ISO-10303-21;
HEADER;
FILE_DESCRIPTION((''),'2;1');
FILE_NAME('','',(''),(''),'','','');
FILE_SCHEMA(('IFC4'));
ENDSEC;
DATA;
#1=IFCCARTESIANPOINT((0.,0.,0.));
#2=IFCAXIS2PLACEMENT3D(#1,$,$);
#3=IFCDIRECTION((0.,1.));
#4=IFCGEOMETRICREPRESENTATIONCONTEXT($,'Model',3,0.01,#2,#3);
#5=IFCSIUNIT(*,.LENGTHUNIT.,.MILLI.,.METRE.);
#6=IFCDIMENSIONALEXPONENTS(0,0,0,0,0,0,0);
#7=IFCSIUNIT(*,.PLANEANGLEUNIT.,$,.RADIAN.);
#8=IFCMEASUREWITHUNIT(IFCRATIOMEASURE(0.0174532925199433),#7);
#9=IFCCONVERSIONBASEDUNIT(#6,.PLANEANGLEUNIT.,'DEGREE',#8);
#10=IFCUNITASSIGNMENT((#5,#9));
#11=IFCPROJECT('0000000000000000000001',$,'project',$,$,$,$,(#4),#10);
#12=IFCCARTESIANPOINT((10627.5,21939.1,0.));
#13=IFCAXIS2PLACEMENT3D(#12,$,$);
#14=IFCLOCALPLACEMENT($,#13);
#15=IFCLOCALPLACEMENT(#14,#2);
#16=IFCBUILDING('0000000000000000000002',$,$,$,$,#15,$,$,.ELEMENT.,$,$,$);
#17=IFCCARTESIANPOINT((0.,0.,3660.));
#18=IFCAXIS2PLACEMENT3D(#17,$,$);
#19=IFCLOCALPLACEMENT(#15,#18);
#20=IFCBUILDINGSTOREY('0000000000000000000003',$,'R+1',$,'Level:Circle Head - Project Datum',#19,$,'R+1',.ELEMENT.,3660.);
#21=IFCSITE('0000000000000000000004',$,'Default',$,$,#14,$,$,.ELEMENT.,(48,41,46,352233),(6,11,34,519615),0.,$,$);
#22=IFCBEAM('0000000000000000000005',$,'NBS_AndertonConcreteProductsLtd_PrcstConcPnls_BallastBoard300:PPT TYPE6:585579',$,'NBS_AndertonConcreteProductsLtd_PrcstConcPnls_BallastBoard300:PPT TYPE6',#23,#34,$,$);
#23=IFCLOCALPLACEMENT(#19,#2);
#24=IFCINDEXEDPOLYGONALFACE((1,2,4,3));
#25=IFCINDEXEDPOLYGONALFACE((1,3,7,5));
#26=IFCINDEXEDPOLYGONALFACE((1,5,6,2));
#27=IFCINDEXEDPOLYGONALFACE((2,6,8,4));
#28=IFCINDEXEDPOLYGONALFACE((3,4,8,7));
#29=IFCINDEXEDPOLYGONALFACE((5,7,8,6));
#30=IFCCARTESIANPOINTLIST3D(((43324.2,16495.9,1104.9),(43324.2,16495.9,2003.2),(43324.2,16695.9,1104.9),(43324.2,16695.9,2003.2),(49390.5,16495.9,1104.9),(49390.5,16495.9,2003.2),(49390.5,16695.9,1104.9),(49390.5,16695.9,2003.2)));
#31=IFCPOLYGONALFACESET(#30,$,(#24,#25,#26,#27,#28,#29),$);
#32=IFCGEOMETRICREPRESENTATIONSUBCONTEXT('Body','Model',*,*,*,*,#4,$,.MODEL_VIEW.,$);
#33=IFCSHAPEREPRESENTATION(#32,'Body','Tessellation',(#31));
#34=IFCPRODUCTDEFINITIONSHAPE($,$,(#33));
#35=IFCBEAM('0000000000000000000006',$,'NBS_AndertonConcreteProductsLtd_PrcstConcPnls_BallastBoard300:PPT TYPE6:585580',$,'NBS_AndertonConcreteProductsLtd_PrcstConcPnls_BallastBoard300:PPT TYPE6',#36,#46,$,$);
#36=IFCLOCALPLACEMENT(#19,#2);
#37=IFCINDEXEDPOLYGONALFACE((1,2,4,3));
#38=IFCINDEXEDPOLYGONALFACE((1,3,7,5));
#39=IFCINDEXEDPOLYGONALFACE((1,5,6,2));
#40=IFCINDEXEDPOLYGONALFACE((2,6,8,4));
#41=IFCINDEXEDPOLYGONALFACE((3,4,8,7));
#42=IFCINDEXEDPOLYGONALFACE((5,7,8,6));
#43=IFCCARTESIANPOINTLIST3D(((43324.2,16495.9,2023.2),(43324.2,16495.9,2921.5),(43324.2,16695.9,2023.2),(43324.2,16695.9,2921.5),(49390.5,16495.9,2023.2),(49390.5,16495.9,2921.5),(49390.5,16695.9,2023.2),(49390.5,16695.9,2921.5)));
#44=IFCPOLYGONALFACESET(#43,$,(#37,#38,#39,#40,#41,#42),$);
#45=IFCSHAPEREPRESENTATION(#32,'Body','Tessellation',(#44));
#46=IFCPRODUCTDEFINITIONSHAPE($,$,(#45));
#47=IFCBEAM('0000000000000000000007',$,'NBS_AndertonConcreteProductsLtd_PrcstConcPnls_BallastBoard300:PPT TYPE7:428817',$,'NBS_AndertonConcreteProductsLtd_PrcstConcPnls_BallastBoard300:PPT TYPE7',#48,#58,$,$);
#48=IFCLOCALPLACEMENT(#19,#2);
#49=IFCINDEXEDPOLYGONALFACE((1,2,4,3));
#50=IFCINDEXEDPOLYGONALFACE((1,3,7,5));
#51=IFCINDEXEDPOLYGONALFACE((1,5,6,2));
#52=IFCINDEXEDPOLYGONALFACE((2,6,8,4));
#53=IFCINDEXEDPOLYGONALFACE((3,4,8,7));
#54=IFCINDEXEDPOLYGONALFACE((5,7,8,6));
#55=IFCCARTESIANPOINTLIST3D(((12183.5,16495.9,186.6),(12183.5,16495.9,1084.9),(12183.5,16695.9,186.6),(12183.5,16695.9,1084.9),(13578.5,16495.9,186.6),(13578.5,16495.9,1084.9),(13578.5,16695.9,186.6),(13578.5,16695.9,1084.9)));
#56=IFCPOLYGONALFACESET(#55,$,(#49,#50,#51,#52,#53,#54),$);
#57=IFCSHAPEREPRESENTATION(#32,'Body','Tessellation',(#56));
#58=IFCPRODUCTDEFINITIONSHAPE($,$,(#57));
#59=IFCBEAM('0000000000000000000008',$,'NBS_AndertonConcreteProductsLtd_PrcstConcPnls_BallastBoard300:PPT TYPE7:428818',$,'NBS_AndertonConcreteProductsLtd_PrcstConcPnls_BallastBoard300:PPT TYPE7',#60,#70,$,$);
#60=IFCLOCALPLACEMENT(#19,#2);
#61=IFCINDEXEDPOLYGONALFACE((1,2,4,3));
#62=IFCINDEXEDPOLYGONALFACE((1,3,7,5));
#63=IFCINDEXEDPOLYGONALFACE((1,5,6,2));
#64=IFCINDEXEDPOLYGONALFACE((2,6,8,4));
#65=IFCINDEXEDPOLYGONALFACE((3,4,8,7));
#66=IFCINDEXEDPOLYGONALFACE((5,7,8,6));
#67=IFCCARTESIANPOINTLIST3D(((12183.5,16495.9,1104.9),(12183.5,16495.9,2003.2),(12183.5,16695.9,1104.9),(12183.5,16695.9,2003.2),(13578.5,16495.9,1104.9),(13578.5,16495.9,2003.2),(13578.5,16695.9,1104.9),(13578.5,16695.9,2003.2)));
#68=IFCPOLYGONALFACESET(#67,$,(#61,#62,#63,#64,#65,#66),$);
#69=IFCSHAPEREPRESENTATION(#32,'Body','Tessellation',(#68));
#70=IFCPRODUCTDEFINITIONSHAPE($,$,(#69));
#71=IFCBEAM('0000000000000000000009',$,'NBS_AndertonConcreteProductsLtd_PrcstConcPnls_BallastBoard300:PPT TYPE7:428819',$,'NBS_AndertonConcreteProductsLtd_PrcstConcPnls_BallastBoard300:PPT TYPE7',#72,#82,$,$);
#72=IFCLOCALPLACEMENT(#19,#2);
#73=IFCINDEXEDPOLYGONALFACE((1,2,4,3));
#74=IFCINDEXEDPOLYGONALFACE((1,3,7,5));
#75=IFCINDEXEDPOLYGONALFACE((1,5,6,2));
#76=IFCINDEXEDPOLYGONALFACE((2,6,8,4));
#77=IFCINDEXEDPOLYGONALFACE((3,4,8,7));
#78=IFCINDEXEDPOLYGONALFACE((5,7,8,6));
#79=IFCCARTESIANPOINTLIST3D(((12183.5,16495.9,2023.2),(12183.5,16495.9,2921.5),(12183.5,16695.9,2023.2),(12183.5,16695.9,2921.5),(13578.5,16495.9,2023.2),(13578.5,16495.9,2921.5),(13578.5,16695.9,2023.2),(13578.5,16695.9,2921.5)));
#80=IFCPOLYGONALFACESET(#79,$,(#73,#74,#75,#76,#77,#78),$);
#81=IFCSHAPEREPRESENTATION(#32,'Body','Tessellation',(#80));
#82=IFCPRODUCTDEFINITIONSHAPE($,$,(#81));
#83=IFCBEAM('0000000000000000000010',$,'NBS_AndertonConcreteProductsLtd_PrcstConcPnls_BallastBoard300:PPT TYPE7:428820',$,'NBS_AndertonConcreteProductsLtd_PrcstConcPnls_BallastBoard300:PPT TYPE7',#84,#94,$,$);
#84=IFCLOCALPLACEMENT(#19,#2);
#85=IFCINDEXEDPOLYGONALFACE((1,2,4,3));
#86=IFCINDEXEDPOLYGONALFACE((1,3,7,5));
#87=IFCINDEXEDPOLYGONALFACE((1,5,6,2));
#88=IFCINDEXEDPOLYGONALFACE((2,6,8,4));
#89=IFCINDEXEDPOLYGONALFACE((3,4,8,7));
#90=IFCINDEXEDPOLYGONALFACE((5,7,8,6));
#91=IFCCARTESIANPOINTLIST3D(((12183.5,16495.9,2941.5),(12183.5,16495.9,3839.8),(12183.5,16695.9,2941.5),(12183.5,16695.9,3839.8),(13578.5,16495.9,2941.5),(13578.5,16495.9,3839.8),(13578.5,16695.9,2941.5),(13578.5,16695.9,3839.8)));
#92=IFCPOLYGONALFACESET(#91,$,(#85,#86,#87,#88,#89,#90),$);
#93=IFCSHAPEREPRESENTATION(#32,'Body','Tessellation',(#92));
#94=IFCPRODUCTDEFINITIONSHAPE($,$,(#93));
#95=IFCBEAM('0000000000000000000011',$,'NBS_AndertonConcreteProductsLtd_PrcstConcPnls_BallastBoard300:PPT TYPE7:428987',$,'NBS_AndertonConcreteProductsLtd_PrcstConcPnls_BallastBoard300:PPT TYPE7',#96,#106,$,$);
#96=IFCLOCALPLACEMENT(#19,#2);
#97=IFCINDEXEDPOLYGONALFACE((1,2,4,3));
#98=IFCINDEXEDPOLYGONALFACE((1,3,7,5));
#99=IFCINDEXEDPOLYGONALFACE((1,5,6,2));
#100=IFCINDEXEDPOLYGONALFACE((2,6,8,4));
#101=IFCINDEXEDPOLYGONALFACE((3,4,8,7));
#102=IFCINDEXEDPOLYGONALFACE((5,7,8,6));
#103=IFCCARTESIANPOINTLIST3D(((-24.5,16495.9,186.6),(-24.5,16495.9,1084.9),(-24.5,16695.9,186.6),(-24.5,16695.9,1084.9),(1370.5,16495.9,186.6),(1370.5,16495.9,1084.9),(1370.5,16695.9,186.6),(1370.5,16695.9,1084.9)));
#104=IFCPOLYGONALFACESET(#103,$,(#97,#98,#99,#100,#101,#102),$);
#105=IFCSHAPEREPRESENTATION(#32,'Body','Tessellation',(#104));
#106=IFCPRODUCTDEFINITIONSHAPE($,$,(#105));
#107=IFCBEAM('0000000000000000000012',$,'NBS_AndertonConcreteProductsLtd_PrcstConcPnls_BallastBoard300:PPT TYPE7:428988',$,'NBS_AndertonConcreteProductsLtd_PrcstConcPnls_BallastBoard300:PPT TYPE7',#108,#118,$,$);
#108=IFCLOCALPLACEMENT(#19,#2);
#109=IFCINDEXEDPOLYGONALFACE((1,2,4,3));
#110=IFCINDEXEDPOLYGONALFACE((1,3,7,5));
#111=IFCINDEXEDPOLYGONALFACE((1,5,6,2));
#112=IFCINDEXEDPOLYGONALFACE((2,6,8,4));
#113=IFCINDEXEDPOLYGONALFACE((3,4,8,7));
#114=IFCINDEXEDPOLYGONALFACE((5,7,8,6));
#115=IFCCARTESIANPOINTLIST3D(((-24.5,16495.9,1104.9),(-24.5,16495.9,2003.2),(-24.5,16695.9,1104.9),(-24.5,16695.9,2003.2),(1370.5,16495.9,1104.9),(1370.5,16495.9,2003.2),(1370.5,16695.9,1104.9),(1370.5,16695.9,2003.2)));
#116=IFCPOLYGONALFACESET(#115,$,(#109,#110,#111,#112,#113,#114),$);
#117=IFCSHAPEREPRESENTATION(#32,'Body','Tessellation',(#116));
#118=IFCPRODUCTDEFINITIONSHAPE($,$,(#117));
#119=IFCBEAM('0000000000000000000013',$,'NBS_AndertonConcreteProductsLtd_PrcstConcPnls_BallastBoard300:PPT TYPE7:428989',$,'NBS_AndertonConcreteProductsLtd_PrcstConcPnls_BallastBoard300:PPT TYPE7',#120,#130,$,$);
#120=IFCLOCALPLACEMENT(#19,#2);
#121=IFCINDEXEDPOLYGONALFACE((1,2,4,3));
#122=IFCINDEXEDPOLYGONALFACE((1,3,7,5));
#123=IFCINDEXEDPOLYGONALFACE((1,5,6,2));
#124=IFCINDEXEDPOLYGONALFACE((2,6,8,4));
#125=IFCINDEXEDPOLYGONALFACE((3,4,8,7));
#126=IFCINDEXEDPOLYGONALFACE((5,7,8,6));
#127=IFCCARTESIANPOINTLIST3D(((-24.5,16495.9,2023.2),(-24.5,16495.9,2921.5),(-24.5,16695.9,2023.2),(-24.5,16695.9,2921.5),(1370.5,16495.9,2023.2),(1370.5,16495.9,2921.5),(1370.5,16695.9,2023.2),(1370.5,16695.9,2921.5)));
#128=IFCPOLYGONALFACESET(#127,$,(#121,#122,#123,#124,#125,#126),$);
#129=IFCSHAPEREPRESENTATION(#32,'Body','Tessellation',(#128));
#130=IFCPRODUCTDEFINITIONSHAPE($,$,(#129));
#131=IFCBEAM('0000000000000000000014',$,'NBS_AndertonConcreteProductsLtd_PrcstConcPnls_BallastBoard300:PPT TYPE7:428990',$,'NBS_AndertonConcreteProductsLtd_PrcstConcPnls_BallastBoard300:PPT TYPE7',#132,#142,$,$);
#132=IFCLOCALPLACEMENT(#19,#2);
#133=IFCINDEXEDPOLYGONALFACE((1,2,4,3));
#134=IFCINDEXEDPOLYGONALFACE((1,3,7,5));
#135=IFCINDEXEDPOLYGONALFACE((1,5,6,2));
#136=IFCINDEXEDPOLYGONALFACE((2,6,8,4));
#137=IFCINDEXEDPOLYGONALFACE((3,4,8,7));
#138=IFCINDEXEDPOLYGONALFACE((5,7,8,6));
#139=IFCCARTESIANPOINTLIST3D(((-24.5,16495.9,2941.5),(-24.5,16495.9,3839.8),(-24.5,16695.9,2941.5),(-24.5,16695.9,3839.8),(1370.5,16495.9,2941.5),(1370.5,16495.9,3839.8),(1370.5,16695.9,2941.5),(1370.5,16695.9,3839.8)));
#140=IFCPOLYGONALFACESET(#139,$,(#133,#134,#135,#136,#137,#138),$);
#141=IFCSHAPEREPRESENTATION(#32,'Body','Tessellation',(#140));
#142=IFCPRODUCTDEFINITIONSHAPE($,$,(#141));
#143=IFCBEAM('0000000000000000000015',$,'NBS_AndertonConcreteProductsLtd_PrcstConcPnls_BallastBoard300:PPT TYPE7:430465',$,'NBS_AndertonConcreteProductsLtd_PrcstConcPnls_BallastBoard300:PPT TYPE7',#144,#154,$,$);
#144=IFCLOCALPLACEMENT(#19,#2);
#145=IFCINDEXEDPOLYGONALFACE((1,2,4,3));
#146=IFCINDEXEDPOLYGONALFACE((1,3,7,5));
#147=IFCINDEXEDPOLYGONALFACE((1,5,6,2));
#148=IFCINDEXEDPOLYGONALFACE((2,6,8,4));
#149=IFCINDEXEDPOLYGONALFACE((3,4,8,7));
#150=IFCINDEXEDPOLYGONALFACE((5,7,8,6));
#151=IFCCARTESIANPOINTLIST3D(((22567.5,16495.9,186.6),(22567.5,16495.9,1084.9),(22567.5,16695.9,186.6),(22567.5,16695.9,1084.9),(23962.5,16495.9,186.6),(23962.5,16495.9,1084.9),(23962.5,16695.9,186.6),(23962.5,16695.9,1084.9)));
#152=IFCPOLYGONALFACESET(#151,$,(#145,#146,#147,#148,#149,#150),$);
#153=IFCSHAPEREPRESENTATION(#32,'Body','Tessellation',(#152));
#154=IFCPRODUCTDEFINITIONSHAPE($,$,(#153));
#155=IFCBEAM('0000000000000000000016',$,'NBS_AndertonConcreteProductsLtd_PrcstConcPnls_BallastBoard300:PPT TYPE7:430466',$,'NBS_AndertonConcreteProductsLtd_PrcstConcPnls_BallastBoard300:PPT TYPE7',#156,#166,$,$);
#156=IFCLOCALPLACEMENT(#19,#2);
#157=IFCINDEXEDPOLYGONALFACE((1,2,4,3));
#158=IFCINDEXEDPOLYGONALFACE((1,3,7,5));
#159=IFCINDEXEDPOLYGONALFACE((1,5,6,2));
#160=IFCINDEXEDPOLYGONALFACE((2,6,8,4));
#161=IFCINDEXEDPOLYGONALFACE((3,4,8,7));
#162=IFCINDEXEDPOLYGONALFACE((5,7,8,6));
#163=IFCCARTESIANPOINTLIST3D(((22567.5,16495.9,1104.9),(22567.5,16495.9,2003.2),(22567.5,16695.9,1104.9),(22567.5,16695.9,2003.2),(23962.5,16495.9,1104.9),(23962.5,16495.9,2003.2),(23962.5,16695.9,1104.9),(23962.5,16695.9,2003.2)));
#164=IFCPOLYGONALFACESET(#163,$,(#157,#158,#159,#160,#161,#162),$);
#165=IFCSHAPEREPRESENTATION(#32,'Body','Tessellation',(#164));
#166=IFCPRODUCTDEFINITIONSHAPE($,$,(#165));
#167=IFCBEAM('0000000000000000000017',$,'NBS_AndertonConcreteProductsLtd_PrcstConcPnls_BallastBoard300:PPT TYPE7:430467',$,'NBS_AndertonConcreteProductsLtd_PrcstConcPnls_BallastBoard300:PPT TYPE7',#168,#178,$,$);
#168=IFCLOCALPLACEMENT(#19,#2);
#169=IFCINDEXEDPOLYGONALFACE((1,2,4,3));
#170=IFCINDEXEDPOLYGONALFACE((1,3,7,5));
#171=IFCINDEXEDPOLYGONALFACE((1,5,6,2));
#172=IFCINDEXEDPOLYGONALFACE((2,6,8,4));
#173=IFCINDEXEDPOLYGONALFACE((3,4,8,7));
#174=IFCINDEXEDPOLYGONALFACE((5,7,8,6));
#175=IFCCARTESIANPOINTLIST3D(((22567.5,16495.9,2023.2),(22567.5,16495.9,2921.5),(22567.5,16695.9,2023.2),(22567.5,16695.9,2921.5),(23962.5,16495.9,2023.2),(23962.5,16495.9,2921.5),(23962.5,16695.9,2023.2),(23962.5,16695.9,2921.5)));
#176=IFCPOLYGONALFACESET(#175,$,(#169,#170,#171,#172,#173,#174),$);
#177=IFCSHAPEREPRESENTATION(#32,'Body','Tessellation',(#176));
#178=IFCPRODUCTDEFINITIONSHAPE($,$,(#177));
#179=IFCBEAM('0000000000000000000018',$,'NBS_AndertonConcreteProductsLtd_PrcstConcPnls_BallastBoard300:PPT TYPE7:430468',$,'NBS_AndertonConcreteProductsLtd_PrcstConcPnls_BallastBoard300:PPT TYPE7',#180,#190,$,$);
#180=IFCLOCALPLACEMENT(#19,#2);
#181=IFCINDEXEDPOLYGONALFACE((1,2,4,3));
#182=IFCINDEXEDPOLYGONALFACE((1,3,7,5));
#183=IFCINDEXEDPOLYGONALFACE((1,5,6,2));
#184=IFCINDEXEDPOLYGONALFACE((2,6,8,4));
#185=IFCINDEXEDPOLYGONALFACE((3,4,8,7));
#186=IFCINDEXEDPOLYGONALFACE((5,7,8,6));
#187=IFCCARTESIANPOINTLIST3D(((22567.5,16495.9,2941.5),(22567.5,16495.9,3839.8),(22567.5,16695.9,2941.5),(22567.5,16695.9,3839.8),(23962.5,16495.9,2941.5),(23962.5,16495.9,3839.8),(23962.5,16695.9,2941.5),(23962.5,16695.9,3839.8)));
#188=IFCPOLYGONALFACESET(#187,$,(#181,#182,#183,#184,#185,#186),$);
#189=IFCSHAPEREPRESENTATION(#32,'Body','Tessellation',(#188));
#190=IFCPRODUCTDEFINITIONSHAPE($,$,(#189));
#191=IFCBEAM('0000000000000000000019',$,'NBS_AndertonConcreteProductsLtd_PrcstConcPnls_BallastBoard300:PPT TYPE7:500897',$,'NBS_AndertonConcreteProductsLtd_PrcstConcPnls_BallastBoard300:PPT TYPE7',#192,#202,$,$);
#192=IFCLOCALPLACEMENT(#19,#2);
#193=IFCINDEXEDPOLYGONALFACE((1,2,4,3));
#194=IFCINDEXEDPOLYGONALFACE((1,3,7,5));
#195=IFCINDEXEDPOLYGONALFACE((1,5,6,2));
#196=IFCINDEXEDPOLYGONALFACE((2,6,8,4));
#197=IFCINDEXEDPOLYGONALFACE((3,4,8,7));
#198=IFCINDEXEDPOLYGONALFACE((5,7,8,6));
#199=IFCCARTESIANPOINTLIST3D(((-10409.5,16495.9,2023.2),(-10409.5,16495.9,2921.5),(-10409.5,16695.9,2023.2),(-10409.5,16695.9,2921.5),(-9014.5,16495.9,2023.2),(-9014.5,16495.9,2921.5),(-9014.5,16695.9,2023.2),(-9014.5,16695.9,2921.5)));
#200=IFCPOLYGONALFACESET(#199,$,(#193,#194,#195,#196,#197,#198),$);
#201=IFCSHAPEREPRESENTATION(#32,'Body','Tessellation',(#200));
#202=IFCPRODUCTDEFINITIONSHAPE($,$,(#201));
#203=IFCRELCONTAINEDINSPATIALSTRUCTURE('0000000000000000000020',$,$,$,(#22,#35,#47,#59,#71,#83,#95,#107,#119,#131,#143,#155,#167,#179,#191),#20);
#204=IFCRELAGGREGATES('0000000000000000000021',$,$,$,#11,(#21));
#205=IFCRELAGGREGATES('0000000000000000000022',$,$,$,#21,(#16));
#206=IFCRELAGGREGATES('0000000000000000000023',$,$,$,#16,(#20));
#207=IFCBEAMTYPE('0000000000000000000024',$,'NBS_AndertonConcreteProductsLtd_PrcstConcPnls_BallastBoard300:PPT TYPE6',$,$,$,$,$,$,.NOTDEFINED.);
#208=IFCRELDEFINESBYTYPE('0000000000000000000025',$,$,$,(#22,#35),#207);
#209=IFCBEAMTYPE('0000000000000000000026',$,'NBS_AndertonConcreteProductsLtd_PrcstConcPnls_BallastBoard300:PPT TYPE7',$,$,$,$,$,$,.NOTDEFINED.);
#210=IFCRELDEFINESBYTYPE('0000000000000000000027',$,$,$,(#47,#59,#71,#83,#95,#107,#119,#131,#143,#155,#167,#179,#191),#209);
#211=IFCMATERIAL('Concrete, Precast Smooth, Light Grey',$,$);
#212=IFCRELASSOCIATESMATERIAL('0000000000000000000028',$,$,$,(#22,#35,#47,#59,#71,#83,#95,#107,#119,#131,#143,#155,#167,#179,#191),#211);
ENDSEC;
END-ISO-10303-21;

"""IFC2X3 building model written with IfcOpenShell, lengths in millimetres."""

from ifc_helpers import new_model, entity, si_unit, converted_unit, direction, frame, frame_2d, origin, place, context, subcontext, project, spatial, rectangle, extrude, material, type_object, element, save


model = new_model("IFC2X3")

# Units and contexts
model_context = context("Model", 3, precision=0.01, world=origin(), true_north=direction((0.0, 1.0)))
body_context = subcontext(model_context, "Body", "Model", "MODEL_VIEW")
ifc_project = project(units=[si_unit("LENGTHUNIT", "METRE", prefix="MILLI"), converted_unit("PLANEANGLEUNIT", "DEGREE", entity("IfcRatioMeasure", 0.0174532925199433), si_unit("PLANEANGLEUNIT", "RADIAN"), dimensions=[0, 0, 0, 0, 0, 0, 0])], contexts=[model_context])

# Site, building, storey
site_placement = place(None, frame((10627.5, 21939.1, 0.0)))
site = spatial("IfcSite", under=ifc_project, at=site_placement, Name="Default", CompositionType="ELEMENT", RefLatitude=(48, 41, 46, 352233), RefLongitude=(6, 11, 34, 519615), RefElevation=0.0)
building_placement = place(site_placement, origin())
building = spatial("IfcBuilding", under=site, at=building_placement, CompositionType="ELEMENT")
storey_placement = place(building_placement, frame((0.0, 0.0, 3660.0)))
storey = spatial("IfcBuildingStorey", under=building, at=storey_placement, Name="R+1", ObjectType="Level:Circle Head - Project Datum", LongName="R+1", CompositionType="ELEMENT", Elevation=3660.0)

# Beams
ifc_material = material(Name="Concrete, Precast Smooth, Light Grey")
beam_type_1 = type_object("IfcBeamType", Name="NBS_AndertonConcreteProductsLtd_PrcstConcPnls_BallastBoard300:PPT TYPE6", PredefinedType="NOTDEFINED")
beam_1_placement = place(storey_placement, origin())
element("IfcBeam", 1, at=beam_1_placement, inside=storey, type_object=beam_type_1, material=ifc_material, Name="NBS_AndertonConcreteProductsLtd_PrcstConcPnls_BallastBoard300:PPT TYPE6:585579", ObjectType="NBS_AndertonConcreteProductsLtd_PrcstConcPnls_BallastBoard300:PPT TYPE6", context=body_context, shape_type="SweptSolid", body=[
    extrude(rectangle(XDim=898.3, YDim=200.0, at=frame_2d((0.0, 0.0), x_axis=(1.0, 0.0))), frame((43324.2, 16595.9, 1554.1), z_axis=(1.0, 0.0, 0.0), x_axis=(0.0, 0.0, -1.0)), (0.0, 0.0, 1.0), 6066.3),
])
beam_2_placement = place(storey_placement, origin())
element("IfcBeam", 2, at=beam_2_placement, inside=storey, type_object=beam_type_1, material=ifc_material, Name="NBS_AndertonConcreteProductsLtd_PrcstConcPnls_BallastBoard300:PPT TYPE6:585580", ObjectType="NBS_AndertonConcreteProductsLtd_PrcstConcPnls_BallastBoard300:PPT TYPE6", context=body_context, shape_type="SweptSolid", body=[
    extrude(rectangle(XDim=898.3, YDim=200.0, at=frame_2d((0.0, 0.0), x_axis=(1.0, 0.0))), frame((43324.2, 16595.9, 2472.4), z_axis=(1.0, 0.0, 0.0), x_axis=(0.0, 0.0, -1.0)), (0.0, 0.0, 1.0), 6066.3),
])
beam_type_2 = type_object("IfcBeamType", Name="NBS_AndertonConcreteProductsLtd_PrcstConcPnls_BallastBoard300:PPT TYPE7", PredefinedType="NOTDEFINED")
beam_3_placement = place(storey_placement, origin())
element("IfcBeam", 3, at=beam_3_placement, inside=storey, type_object=beam_type_2, material=ifc_material, Name="NBS_AndertonConcreteProductsLtd_PrcstConcPnls_BallastBoard300:PPT TYPE7:428817", ObjectType="NBS_AndertonConcreteProductsLtd_PrcstConcPnls_BallastBoard300:PPT TYPE7", context=body_context, shape_type="SweptSolid", body=[
    extrude(rectangle(XDim=898.3, YDim=200.0, at=frame_2d((0.0, 0.0), x_axis=(0.0, 1.0))), frame((12183.5, 16595.9, 635.8), z_axis=(1.0, 0.0, 0.0), x_axis=(0.0, 1.0, 0.0)), (0.0, 0.0, 1.0), 1395.0),
])
beam_4_placement = place(storey_placement, origin())
element("IfcBeam", 4, at=beam_4_placement, inside=storey, type_object=beam_type_2, material=ifc_material, Name="NBS_AndertonConcreteProductsLtd_PrcstConcPnls_BallastBoard300:PPT TYPE7:428818", ObjectType="NBS_AndertonConcreteProductsLtd_PrcstConcPnls_BallastBoard300:PPT TYPE7", context=body_context, shape_type="SweptSolid", body=[
    extrude(rectangle(XDim=898.3, YDim=200.0, at=frame_2d((0.0, 0.0), x_axis=(0.0, 1.0))), frame((12183.5, 16595.9, 1554.1), z_axis=(1.0, 0.0, 0.0), x_axis=(0.0, 1.0, 0.0)), (0.0, 0.0, 1.0), 1395.0),
])
beam_5_placement = place(storey_placement, origin())
element("IfcBeam", 5, at=beam_5_placement, inside=storey, type_object=beam_type_2, material=ifc_material, Name="NBS_AndertonConcreteProductsLtd_PrcstConcPnls_BallastBoard300:PPT TYPE7:428819", ObjectType="NBS_AndertonConcreteProductsLtd_PrcstConcPnls_BallastBoard300:PPT TYPE7", context=body_context, shape_type="SweptSolid", body=[
    extrude(rectangle(XDim=898.3, YDim=200.0, at=frame_2d((0.0, 0.0), x_axis=(0.0, 1.0))), frame((12183.5, 16595.9, 2472.4), z_axis=(1.0, 0.0, 0.0), x_axis=(0.0, 1.0, 0.0)), (0.0, 0.0, 1.0), 1395.0),
])
beam_6_placement = place(storey_placement, origin())
element("IfcBeam", 6, at=beam_6_placement, inside=storey, type_object=beam_type_2, material=ifc_material, Name="NBS_AndertonConcreteProductsLtd_PrcstConcPnls_BallastBoard300:PPT TYPE7:428820", ObjectType="NBS_AndertonConcreteProductsLtd_PrcstConcPnls_BallastBoard300:PPT TYPE7", context=body_context, shape_type="SweptSolid", body=[
    extrude(rectangle(XDim=898.3, YDim=200.0, at=frame_2d((0.0, 0.0), x_axis=(0.0, 1.0))), frame((12183.5, 16595.9, 3390.7), z_axis=(1.0, 0.0, 0.0), x_axis=(0.0, 1.0, 0.0)), (0.0, 0.0, 1.0), 1395.0),
])
beam_7_placement = place(storey_placement, origin())
element("IfcBeam", 7, at=beam_7_placement, inside=storey, type_object=beam_type_2, material=ifc_material, Name="NBS_AndertonConcreteProductsLtd_PrcstConcPnls_BallastBoard300:PPT TYPE7:428987", ObjectType="NBS_AndertonConcreteProductsLtd_PrcstConcPnls_BallastBoard300:PPT TYPE7", context=body_context, shape_type="SweptSolid", body=[
    extrude(rectangle(XDim=898.3, YDim=200.0, at=frame_2d((0.0, 0.0), x_axis=(0.0, 1.0))), frame((-24.5, 16595.9, 635.8), z_axis=(1.0, 0.0, 0.0), x_axis=(0.0, 1.0, 0.0)), (0.0, 0.0, 1.0), 1395.0),
])
beam_8_placement = place(storey_placement, origin())
element("IfcBeam", 8, at=beam_8_placement, inside=storey, type_object=beam_type_2, material=ifc_material, Name="NBS_AndertonConcreteProductsLtd_PrcstConcPnls_BallastBoard300:PPT TYPE7:428988", ObjectType="NBS_AndertonConcreteProductsLtd_PrcstConcPnls_BallastBoard300:PPT TYPE7", context=body_context, shape_type="SweptSolid", body=[
    extrude(rectangle(XDim=898.3, YDim=200.0, at=frame_2d((0.0, 0.0), x_axis=(0.0, 1.0))), frame((-24.5, 16595.9, 1554.1), z_axis=(1.0, 0.0, 0.0), x_axis=(0.0, 1.0, 0.0)), (0.0, 0.0, 1.0), 1395.0),
])
beam_9_placement = place(storey_placement, origin())
element("IfcBeam", 9, at=beam_9_placement, inside=storey, type_object=beam_type_2, material=ifc_material, Name="NBS_AndertonConcreteProductsLtd_PrcstConcPnls_BallastBoard300:PPT TYPE7:428989", ObjectType="NBS_AndertonConcreteProductsLtd_PrcstConcPnls_BallastBoard300:PPT TYPE7", context=body_context, shape_type="SweptSolid", body=[
    extrude(rectangle(XDim=898.3, YDim=200.0, at=frame_2d((0.0, 0.0), x_axis=(0.0, 1.0))), frame((-24.5, 16595.9, 2472.4), z_axis=(1.0, 0.0, 0.0), x_axis=(0.0, 1.0, 0.0)), (0.0, 0.0, 1.0), 1395.0),
])
beam_10_placement = place(storey_placement, origin())
element("IfcBeam", 10, at=beam_10_placement, inside=storey, type_object=beam_type_2, material=ifc_material, Name="NBS_AndertonConcreteProductsLtd_PrcstConcPnls_BallastBoard300:PPT TYPE7:428990", ObjectType="NBS_AndertonConcreteProductsLtd_PrcstConcPnls_BallastBoard300:PPT TYPE7", context=body_context, shape_type="SweptSolid", body=[
    extrude(rectangle(XDim=898.3, YDim=200.0, at=frame_2d((0.0, 0.0), x_axis=(0.0, 1.0))), frame((-24.5, 16595.9, 3390.7), z_axis=(1.0, 0.0, 0.0), x_axis=(0.0, 1.0, 0.0)), (0.0, 0.0, 1.0), 1395.0),
])
beam_11_placement = place(storey_placement, origin())
element("IfcBeam", 11, at=beam_11_placement, inside=storey, type_object=beam_type_2, material=ifc_material, Name="NBS_AndertonConcreteProductsLtd_PrcstConcPnls_BallastBoard300:PPT TYPE7:430465", ObjectType="NBS_AndertonConcreteProductsLtd_PrcstConcPnls_BallastBoard300:PPT TYPE7", context=body_context, shape_type="SweptSolid", body=[
    extrude(rectangle(XDim=898.3, YDim=200.0, at=frame_2d((0.0, 0.0), x_axis=(0.0, 1.0))), frame((22567.5, 16595.9, 635.8), z_axis=(1.0, 0.0, 0.0), x_axis=(0.0, 1.0, 0.0)), (0.0, 0.0, 1.0), 1395.0),
])
beam_12_placement = place(storey_placement, origin())
element("IfcBeam", 12, at=beam_12_placement, inside=storey, type_object=beam_type_2, material=ifc_material, Name="NBS_AndertonConcreteProductsLtd_PrcstConcPnls_BallastBoard300:PPT TYPE7:430466", ObjectType="NBS_AndertonConcreteProductsLtd_PrcstConcPnls_BallastBoard300:PPT TYPE7", context=body_context, shape_type="SweptSolid", body=[
    extrude(rectangle(XDim=898.3, YDim=200.0, at=frame_2d((0.0, 0.0), x_axis=(0.0, 1.0))), frame((22567.5, 16595.9, 1554.1), z_axis=(1.0, 0.0, 0.0), x_axis=(0.0, 1.0, 0.0)), (0.0, 0.0, 1.0), 1395.0),
])
beam_13_placement = place(storey_placement, origin())
element("IfcBeam", 13, at=beam_13_placement, inside=storey, type_object=beam_type_2, material=ifc_material, Name="NBS_AndertonConcreteProductsLtd_PrcstConcPnls_BallastBoard300:PPT TYPE7:430467", ObjectType="NBS_AndertonConcreteProductsLtd_PrcstConcPnls_BallastBoard300:PPT TYPE7", context=body_context, shape_type="SweptSolid", body=[
    extrude(rectangle(XDim=898.3, YDim=200.0, at=frame_2d((0.0, 0.0), x_axis=(0.0, 1.0))), frame((22567.5, 16595.9, 2472.4), z_axis=(1.0, 0.0, 0.0), x_axis=(0.0, 1.0, 0.0)), (0.0, 0.0, 1.0), 1395.0),
])
beam_14_placement = place(storey_placement, origin())
element("IfcBeam", 14, at=beam_14_placement, inside=storey, type_object=beam_type_2, material=ifc_material, Name="NBS_AndertonConcreteProductsLtd_PrcstConcPnls_BallastBoard300:PPT TYPE7:430468", ObjectType="NBS_AndertonConcreteProductsLtd_PrcstConcPnls_BallastBoard300:PPT TYPE7", context=body_context, shape_type="SweptSolid", body=[
    extrude(rectangle(XDim=898.3, YDim=200.0, at=frame_2d((0.0, 0.0), x_axis=(0.0, 1.0))), frame((22567.5, 16595.9, 3390.7), z_axis=(1.0, 0.0, 0.0), x_axis=(0.0, 1.0, 0.0)), (0.0, 0.0, 1.0), 1395.0),
])
beam_15_placement = place(storey_placement, origin())
element("IfcBeam", 15, at=beam_15_placement, inside=storey, type_object=beam_type_2, material=ifc_material, Name="NBS_AndertonConcreteProductsLtd_PrcstConcPnls_BallastBoard300:PPT TYPE7:500897", ObjectType="NBS_AndertonConcreteProductsLtd_PrcstConcPnls_BallastBoard300:PPT TYPE7", context=body_context, shape_type="SweptSolid", body=[
    extrude(rectangle(XDim=898.3, YDim=200.0, at=frame_2d((0.0, 0.0), x_axis=(0.0, 1.0))), frame((-10409.5, 16595.9, 2472.4), z_axis=(1.0, 0.0, 0.0), x_axis=(0.0, 1.0, 0.0)), (0.0, 0.0, 1.0), 1395.0),
])

save(model, "model.ifc")
